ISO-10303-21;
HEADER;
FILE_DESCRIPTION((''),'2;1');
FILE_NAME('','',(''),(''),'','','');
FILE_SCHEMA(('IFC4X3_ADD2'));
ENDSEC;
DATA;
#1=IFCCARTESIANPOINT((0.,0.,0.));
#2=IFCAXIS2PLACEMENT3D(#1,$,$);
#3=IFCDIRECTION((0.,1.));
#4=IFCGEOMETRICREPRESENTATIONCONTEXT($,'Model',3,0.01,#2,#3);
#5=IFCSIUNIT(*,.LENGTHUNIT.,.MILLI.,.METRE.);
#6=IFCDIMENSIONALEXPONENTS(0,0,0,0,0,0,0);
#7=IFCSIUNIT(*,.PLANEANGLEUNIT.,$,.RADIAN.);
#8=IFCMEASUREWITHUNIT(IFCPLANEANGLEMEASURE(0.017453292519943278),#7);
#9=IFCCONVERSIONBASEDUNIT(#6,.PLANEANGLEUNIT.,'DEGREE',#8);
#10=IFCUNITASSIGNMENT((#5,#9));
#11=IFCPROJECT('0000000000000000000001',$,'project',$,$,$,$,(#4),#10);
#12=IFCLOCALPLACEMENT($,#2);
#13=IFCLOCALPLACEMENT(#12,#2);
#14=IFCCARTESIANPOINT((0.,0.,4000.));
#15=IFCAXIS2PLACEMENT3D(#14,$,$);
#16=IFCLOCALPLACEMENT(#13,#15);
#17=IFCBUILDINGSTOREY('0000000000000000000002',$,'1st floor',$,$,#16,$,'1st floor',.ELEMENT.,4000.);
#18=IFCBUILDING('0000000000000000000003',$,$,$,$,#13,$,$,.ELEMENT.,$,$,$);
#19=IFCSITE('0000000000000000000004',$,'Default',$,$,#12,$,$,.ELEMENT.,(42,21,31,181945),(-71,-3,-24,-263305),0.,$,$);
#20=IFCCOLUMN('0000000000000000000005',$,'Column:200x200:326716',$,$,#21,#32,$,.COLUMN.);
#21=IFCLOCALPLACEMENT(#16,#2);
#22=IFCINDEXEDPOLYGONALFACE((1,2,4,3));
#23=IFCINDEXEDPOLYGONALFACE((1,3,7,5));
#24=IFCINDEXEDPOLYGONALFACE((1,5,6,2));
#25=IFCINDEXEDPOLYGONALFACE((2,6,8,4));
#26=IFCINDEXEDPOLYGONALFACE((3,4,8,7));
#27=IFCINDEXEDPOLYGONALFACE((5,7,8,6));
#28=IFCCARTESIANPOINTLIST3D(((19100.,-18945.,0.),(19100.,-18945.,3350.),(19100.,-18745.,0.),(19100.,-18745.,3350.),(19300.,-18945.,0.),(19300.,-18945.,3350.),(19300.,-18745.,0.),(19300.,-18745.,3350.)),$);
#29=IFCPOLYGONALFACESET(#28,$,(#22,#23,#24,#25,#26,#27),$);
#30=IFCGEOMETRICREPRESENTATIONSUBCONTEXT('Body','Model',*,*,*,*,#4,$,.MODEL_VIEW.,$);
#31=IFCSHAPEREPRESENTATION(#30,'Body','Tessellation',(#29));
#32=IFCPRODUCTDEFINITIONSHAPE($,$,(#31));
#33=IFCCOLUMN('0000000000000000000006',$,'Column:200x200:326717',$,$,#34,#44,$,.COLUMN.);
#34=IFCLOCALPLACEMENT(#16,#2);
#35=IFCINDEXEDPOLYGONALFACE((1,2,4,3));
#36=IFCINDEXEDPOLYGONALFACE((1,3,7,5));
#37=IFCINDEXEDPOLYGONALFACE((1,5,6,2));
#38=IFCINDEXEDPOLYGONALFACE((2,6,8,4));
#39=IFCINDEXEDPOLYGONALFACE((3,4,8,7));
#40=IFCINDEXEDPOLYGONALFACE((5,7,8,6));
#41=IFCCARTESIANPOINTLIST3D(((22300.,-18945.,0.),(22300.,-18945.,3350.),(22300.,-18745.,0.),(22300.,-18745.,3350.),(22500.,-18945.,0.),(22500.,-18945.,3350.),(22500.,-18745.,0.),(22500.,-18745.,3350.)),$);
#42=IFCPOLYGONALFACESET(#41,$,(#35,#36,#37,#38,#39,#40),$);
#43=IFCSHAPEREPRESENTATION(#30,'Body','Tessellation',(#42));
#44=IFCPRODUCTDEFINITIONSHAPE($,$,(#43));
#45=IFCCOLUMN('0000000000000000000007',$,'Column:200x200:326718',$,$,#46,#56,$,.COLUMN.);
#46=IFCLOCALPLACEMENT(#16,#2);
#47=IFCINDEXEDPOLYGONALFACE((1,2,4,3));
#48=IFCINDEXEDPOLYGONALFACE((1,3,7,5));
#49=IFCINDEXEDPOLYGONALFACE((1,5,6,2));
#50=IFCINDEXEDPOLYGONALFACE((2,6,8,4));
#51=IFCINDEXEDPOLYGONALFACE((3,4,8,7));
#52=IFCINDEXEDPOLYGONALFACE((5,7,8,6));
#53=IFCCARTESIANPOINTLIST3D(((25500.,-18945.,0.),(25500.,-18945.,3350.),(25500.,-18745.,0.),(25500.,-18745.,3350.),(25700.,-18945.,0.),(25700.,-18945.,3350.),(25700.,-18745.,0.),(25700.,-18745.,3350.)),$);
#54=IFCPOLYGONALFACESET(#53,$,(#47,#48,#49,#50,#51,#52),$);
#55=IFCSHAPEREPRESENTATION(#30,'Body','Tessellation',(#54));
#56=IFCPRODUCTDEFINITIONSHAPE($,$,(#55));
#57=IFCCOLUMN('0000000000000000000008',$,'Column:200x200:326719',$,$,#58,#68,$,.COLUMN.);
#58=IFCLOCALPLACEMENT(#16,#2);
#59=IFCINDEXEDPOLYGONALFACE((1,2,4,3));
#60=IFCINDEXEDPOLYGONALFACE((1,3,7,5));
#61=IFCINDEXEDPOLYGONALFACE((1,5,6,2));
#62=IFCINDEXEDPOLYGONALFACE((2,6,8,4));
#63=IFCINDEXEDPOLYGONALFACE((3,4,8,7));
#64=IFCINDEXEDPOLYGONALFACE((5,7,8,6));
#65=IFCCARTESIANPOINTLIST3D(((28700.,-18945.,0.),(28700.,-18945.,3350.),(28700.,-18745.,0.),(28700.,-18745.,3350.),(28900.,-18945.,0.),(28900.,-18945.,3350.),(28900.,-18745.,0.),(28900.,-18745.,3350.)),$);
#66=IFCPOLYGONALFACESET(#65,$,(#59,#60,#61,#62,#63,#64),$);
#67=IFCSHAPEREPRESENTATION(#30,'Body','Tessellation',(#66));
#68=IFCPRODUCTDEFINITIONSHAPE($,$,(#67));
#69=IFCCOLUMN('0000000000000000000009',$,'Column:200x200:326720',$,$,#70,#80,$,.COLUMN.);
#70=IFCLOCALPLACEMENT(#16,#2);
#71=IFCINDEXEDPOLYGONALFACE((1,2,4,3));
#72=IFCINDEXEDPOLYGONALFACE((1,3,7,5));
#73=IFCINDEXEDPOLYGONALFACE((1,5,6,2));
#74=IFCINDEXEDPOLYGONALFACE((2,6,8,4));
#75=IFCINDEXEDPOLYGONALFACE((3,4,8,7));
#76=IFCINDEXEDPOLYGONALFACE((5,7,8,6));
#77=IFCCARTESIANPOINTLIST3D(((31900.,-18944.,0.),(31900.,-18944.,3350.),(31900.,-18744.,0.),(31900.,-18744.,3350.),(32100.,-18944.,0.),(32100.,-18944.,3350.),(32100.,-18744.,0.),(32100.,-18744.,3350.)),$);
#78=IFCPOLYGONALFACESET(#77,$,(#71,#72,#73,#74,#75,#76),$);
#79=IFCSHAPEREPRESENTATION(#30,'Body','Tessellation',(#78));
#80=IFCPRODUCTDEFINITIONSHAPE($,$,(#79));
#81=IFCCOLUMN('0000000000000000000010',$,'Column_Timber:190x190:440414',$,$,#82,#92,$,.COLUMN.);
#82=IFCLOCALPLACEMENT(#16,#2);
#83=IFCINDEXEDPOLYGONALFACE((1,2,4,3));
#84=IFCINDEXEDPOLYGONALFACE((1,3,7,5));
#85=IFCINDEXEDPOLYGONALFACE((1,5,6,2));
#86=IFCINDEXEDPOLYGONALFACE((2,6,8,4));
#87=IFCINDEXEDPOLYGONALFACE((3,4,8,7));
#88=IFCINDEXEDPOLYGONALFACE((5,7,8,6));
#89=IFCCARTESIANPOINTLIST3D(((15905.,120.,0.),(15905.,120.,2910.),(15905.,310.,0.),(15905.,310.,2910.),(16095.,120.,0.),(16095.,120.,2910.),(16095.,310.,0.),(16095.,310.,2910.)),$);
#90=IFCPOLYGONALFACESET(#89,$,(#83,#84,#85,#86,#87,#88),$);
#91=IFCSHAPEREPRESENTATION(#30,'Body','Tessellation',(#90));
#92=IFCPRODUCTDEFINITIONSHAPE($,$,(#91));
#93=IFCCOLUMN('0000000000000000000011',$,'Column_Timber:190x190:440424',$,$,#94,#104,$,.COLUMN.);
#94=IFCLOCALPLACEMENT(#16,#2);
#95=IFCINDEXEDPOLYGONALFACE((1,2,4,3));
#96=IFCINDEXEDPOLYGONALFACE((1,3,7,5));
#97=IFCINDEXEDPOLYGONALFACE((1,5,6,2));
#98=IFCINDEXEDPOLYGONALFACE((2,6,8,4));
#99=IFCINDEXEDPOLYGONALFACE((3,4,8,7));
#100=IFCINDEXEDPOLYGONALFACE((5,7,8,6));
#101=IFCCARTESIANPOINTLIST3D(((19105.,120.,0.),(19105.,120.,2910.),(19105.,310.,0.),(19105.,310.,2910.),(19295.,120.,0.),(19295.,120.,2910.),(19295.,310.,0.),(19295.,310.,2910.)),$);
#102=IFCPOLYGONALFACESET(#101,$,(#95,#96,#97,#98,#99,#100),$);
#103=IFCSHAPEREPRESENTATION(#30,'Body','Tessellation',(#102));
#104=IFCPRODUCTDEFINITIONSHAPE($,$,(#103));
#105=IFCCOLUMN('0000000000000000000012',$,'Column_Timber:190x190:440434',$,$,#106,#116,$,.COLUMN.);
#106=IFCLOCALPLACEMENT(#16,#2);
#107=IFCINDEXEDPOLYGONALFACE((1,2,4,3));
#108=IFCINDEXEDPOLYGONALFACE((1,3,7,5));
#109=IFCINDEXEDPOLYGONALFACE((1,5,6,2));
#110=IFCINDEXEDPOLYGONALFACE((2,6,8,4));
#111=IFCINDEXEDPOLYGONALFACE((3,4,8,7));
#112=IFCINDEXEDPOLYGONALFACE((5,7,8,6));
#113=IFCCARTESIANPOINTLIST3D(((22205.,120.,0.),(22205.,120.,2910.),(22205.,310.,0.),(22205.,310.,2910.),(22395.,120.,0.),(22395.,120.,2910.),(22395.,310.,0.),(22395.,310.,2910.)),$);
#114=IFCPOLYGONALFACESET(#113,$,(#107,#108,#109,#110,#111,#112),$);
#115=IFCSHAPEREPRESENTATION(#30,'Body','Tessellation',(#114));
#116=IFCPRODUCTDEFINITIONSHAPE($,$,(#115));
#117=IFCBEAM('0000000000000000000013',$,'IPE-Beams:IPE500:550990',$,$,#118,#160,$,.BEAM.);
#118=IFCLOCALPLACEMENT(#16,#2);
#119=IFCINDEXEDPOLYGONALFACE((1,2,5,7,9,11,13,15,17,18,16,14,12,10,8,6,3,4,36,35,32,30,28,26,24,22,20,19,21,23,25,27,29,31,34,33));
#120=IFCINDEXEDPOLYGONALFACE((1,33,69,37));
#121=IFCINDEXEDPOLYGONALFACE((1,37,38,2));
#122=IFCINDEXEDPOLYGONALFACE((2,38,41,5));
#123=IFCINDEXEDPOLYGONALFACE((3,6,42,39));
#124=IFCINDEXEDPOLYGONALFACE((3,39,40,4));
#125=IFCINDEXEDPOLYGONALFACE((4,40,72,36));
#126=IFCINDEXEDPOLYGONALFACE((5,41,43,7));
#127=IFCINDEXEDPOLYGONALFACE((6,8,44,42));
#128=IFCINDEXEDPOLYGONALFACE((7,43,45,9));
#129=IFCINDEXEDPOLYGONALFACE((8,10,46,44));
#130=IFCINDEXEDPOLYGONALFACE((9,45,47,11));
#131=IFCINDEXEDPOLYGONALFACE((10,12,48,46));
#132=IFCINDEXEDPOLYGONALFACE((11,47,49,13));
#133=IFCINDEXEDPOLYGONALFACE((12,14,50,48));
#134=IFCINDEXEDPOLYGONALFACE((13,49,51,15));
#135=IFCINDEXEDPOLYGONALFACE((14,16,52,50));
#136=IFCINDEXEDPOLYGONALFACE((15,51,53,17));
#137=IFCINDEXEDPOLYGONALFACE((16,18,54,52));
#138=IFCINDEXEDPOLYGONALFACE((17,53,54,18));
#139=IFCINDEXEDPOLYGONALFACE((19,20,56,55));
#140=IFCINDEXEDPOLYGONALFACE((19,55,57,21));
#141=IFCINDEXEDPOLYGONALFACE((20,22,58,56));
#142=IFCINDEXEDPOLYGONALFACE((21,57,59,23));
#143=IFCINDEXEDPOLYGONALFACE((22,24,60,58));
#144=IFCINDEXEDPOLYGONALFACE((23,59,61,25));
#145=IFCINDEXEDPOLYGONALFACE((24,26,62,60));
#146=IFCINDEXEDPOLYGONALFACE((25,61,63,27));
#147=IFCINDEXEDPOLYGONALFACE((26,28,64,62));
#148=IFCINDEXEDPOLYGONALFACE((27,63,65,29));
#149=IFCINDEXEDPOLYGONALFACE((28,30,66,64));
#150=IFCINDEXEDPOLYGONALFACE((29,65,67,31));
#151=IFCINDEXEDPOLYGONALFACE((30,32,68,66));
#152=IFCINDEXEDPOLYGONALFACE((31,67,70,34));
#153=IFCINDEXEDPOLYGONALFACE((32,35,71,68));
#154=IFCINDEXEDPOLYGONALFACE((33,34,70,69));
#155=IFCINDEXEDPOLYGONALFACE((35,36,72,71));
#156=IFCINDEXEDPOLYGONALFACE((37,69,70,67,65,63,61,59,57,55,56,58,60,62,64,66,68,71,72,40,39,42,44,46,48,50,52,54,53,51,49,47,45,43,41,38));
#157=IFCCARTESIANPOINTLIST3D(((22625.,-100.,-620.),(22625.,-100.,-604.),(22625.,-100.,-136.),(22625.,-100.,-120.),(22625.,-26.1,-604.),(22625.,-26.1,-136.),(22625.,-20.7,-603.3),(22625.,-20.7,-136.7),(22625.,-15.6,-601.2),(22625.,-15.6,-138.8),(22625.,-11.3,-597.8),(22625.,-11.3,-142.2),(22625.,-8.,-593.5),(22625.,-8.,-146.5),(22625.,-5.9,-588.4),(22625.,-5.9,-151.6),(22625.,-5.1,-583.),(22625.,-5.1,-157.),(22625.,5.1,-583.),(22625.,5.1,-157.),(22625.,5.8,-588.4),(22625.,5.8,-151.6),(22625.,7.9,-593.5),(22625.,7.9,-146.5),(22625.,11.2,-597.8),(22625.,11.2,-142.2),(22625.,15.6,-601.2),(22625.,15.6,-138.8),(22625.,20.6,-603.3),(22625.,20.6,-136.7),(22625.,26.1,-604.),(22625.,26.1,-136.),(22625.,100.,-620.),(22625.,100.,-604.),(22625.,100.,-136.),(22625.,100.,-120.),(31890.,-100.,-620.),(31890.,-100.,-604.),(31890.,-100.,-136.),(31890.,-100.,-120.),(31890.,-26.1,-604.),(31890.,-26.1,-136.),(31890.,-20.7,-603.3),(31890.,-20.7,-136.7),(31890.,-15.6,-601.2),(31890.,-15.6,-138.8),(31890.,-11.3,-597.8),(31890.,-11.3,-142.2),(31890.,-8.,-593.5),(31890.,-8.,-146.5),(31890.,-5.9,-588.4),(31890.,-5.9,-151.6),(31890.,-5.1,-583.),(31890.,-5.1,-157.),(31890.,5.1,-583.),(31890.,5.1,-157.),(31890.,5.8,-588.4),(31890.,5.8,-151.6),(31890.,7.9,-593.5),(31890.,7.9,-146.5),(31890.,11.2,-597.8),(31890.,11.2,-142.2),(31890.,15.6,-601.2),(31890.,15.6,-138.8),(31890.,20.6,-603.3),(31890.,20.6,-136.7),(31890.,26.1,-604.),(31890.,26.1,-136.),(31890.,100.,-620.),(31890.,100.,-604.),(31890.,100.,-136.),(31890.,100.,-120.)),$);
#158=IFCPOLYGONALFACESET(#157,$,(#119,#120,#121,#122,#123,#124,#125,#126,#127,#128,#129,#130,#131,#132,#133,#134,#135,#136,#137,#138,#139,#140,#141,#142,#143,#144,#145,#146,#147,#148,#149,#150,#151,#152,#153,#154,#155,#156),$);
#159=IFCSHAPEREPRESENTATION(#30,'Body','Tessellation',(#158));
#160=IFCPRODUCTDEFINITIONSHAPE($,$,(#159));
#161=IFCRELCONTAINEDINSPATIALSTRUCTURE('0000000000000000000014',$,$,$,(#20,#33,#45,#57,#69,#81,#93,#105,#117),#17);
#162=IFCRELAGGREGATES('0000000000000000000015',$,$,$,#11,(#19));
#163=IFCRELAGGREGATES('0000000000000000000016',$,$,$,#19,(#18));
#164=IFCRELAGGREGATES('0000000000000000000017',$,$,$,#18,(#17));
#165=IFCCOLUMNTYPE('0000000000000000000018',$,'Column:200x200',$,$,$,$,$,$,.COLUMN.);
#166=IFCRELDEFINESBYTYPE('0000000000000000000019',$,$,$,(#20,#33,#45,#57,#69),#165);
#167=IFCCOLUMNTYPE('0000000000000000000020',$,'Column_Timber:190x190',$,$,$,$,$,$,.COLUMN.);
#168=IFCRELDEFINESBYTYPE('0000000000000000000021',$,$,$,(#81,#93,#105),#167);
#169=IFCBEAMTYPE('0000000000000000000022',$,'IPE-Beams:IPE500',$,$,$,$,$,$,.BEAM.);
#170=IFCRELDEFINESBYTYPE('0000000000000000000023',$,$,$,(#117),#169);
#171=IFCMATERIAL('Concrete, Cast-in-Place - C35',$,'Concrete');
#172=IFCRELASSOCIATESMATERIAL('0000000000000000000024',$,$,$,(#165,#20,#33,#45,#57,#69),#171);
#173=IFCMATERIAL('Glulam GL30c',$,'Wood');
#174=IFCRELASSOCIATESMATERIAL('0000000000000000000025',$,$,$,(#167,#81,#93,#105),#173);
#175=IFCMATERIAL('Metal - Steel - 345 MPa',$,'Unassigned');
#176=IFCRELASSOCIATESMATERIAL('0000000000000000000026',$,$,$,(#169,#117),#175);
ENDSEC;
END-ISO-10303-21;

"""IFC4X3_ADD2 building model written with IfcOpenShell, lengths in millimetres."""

from ifc_helpers import new_model, entity, si_unit, converted_unit, direction, frame, frame_2d, origin, origin_2d_with_axis, place, context, subcontext, project, spatial, polyline, circle_curve, parameter, trimmed, segment, composite_curve, rectangle, outline, extrude, source, transform, mapped, material, material_profile, profile_set, profile_usage, type_object, type_shapes, element, save


model = new_model("IFC4X3_ADD2")

# Units and contexts
model_context = context("Model", 3, precision=0.01, world=origin(), true_north=direction((0.0, 1.0)))
body_context = subcontext(model_context, "Body", "Model", "MODEL_VIEW")
ifc_project = project(units=[si_unit("LENGTHUNIT", "METRE", prefix="MILLI"), converted_unit("PLANEANGLEUNIT", "DEGREE", entity("IfcPlaneAngleMeasure", 0.017453292519943278), si_unit("PLANEANGLEUNIT", "RADIAN"), dimensions=[0, 0, 0, 0, 0, 0, 0])], contexts=[model_context])

# Site, building, storey
site_placement = place(None, origin())
site = spatial("IfcSite", under=ifc_project, at=site_placement, Name="Default", CompositionType="ELEMENT", RefLatitude=(42, 21, 31, 181945), RefLongitude=(-71, -3, -24, -263305), RefElevation=0.0)
building_placement = place(site_placement, origin())
building = spatial("IfcBuilding", under=site, at=building_placement, CompositionType="ELEMENT")
storey_placement = place(building_placement, frame((0.0, 0.0, 4000.0)))
storey = spatial("IfcBuildingStorey", under=building, at=storey_placement, Name="1st floor", LongName="1st floor", CompositionType="ELEMENT", Elevation=4000.0)

# Columns
ifc_material_1 = material(Name="Concrete, Cast-in-Place - C35", Category="Concrete")
ifc_material_profile_1 = material_profile(ifc_material_1, rectangle(XDim=200.0, YDim=200.0, at=frame_2d((0.0, 0.0), x_axis=(1.0, 0.0))), Name="200x200")
ifc_profile_set_1 = profile_set([ifc_material_profile_1], Name="200x200")
ifc_profile_usage_1 = profile_usage(ifc_profile_set_1)
column_type_1 = type_object("IfcColumnType", Name="Column:200x200", PredefinedType="COLUMN", material=ifc_profile_set_1)
shared_shape_1 = source(origin(), body_context, "Body", "SweptSolid", [
    extrude(rectangle(XDim=200.0, YDim=200.0, at=frame_2d((0.0, 0.0), x_axis=(1.0, 0.0))), frame((0.0, 0.0, 4000.0), z_axis=(0.0, 0.0, 1.0), x_axis=(-1.0, 0.0, 0.0)), (0.0, 0.0, 1.0), 3350.0),
])
type_shapes(column_type_1, [shared_shape_1])
for number, where, name in (
    (1, (19200.0, -18845.0, -4000.0), "Column:200x200:326716"),
    (2, (22400.0, -18845.0, -4000.0), "Column:200x200:326717"),
    (3, (25600.0, -18845.0, -4000.0), "Column:200x200:326718"),
    (4, (28800.0, -18845.0, -4000.0), "Column:200x200:326719"),
    (5, (32000.0, -18844.0, -4000.0), "Column:200x200:326720"),
):
    element("IfcColumn", number, at=place(storey_placement, frame(where)), inside=storey, type_object=column_type_1, material=ifc_profile_usage_1, Name=name, PredefinedType="COLUMN", context=body_context, shape_type="MappedRepresentation", body=[
        mapped(shared_shape_1, transform((0.0, 0.0, 0.0), scale=1.0)),
    ])
ifc_material_2 = material(Name="Glulam GL30c", Category="Wood")
ifc_material_profile_2 = material_profile(ifc_material_2, rectangle(XDim=190.0, YDim=190.0, at=origin_2d_with_axis()), Name="190x190")
ifc_profile_set_2 = profile_set([ifc_material_profile_2], Name="190x190")
ifc_profile_usage_2 = profile_usage(ifc_profile_set_2)
column_type_2 = type_object("IfcColumnType", Name="Column_Timber:190x190", PredefinedType="COLUMN", material=ifc_profile_set_2)
shared_shape_2 = source(origin(), body_context, "Body", "SweptSolid", [
    extrude(rectangle(XDim=190.0, YDim=190.0, at=origin_2d_with_axis()), frame((0.0, 0.0, 4000.0), z_axis=(0.0, 0.0, 1.0), x_axis=(-1.0, 0.0, 0.0)), (0.0, 0.0, 1.0), 2910.0),
])
type_shapes(column_type_2, [shared_shape_2])
for number, where, name in (
    (6, (16000.0, 215.0, -4000.0), "Column_Timber:190x190:440414"),
    (7, (19200.0, 215.0, -4000.0), "Column_Timber:190x190:440424"),
    (8, (22300.0, 215.0, -4000.0), "Column_Timber:190x190:440434"),
):
    element("IfcColumn", number, at=place(storey_placement, frame(where)), inside=storey, type_object=column_type_2, material=ifc_profile_usage_2, Name=name, PredefinedType="COLUMN", context=body_context, shape_type="MappedRepresentation", body=[
        mapped(shared_shape_2, transform((0.0, 0.0, 0.0), scale=1.0)),
    ])

# Beam
ifc_material_3 = material(Name="Metal - Steel - 345 MPa", Category="Unassigned")
ifc_material_profile_3 = material_profile(ifc_material_3, outline(composite_curve([segment(polyline([(-100.0, -234.0), (-100.0, -250.0)]), True, "CONTINUOUS"), segment(polyline([(-100.0, -250.0), (100.0, -250.0)]), True, "CONTINUOUS"), segment(polyline([(100.0, -250.0), (100.0, -234.0)]), True, "CONTINUOUS"), segment(polyline([(100.0, -234.0), (26.1, -234.0)]), True, "CONTINUOUS"), segment(trimmed(circle_curve(frame_2d((26.1, -213.0), x_axis=(1.0, 0.0)), 21.0), [parameter(180.0)], [parameter(270.0)], True, "PARAMETER"), False, "CONTINUOUS"), segment(polyline([(5.1, -213.0), (5.1, 213.0)]), True, "CONTINUOUS"), segment(trimmed(circle_curve(frame_2d((26.1, 213.0), x_axis=(1.0, 0.0)), 21.0), [parameter(90.0)], [parameter(180.0)], True, "PARAMETER"), False, "CONTINUOUS"), segment(polyline([(26.1, 234.0), (100.0, 234.0)]), True, "CONTINUOUS"), segment(polyline([(100.0, 234.0), (100.0, 250.0)]), True, "CONTINUOUS"), segment(polyline([(100.0, 250.0), (-100.0, 250.0)]), True, "CONTINUOUS"), segment(polyline([(-100.0, 250.0), (-100.0, 234.0)]), True, "CONTINUOUS"), segment(polyline([(-100.0, 234.0), (-26.1, 234.0)]), True, "CONTINUOUS"), segment(trimmed(circle_curve(frame_2d((-26.1, 213.0), x_axis=(1.0, 0.0)), 21.0), [parameter(360.0)], [parameter(90.0)], True, "PARAMETER"), False, "CONTINUOUS"), segment(polyline([(-5.1, 213.0), (-5.1, -213.0)]), True, "CONTINUOUS"), segment(trimmed(circle_curve(frame_2d((-26.1, -213.0), x_axis=(1.0, 0.0)), 21.0), [parameter(270.0)], [parameter(0.0)], True, "PARAMETER"), False, "CONTINUOUS"), segment(polyline([(-26.1, -234.0), (-100.0, -234.0)]), True, "CONTINUOUS")], self_intersect=False)), Name="IPE500")
ifc_profile_set_3 = profile_set([ifc_material_profile_3], Name="IPE500")
ifc_profile_usage_3 = profile_usage(ifc_profile_set_3, cardinal=8)
beam_type = type_object("IfcBeamType", Name="IPE-Beams:IPE500", PredefinedType="BEAM", material=ifc_profile_set_3)
shared_shape_3 = source(origin(), body_context, "Body", "SweptSolid", [
    extrude(outline(composite_curve([segment(polyline([(-100.0, -234.0), (-100.0, -250.0)]), True, "CONTINUOUS"), segment(polyline([(-100.0, -250.0), (100.0, -250.0)]), True, "CONTINUOUS"), segment(polyline([(100.0, -250.0), (100.0, -234.0)]), True, "CONTINUOUS"), segment(polyline([(100.0, -234.0), (26.1, -234.0)]), True, "CONTINUOUS"), segment(trimmed(circle_curve(frame_2d((26.1, -213.0), x_axis=(1.0, 0.0)), 21.0), [parameter(180.0)], [parameter(270.0)], True, "PARAMETER"), False, "CONTINUOUS"), segment(polyline([(5.1, -213.0), (5.1, 213.0)]), True, "CONTINUOUS"), segment(trimmed(circle_curve(frame_2d((26.1, 213.0), x_axis=(1.0, 0.0)), 21.0), [parameter(90.0)], [parameter(180.0)], True, "PARAMETER"), False, "CONTINUOUS"), segment(polyline([(26.1, 234.0), (100.0, 234.0)]), True, "CONTINUOUS"), segment(polyline([(100.0, 234.0), (100.0, 250.0)]), True, "CONTINUOUS"), segment(polyline([(100.0, 250.0), (-100.0, 250.0)]), True, "CONTINUOUS"), segment(polyline([(-100.0, 250.0), (-100.0, 234.0)]), True, "CONTINUOUS"), segment(polyline([(-100.0, 234.0), (-26.1, 234.0)]), True, "CONTINUOUS"), segment(trimmed(circle_curve(frame_2d((-26.1, 213.0), x_axis=(1.0, 0.0)), 21.0), [parameter(360.0)], [parameter(90.0)], True, "PARAMETER"), False, "CONTINUOUS"), segment(polyline([(-5.1, 213.0), (-5.1, -213.0)]), True, "CONTINUOUS"), segment(trimmed(circle_curve(frame_2d((-26.1, -213.0), x_axis=(1.0, 0.0)), 21.0), [parameter(270.0)], [parameter(0.0)], True, "PARAMETER"), False, "CONTINUOUS"), segment(polyline([(-26.1, -234.0), (-100.0, -234.0)]), True, "CONTINUOUS")], self_intersect=False)), frame((-4682.5, 0.0, 0.0), z_axis=(-1.0, 0.0, 0.0), x_axis=(0.0, -1.0, 0.0)), (0.0, 0.0, -1.0), 9265.0),
])
type_shapes(beam_type, [shared_shape_3])
beam_placement = place(storey_placement, frame((27307.5, 0.0, -370.0)))
element("IfcBeam", 9, at=beam_placement, inside=storey, type_object=beam_type, material=ifc_profile_usage_3, Name="IPE-Beams:IPE500:550990", PredefinedType="BEAM", context=body_context, shape_type="MappedRepresentation", body=[
    mapped(shared_shape_3, transform((0.0, 0.0, 0.0), scale=1.0)),
])

save(model, "model.ifc")
